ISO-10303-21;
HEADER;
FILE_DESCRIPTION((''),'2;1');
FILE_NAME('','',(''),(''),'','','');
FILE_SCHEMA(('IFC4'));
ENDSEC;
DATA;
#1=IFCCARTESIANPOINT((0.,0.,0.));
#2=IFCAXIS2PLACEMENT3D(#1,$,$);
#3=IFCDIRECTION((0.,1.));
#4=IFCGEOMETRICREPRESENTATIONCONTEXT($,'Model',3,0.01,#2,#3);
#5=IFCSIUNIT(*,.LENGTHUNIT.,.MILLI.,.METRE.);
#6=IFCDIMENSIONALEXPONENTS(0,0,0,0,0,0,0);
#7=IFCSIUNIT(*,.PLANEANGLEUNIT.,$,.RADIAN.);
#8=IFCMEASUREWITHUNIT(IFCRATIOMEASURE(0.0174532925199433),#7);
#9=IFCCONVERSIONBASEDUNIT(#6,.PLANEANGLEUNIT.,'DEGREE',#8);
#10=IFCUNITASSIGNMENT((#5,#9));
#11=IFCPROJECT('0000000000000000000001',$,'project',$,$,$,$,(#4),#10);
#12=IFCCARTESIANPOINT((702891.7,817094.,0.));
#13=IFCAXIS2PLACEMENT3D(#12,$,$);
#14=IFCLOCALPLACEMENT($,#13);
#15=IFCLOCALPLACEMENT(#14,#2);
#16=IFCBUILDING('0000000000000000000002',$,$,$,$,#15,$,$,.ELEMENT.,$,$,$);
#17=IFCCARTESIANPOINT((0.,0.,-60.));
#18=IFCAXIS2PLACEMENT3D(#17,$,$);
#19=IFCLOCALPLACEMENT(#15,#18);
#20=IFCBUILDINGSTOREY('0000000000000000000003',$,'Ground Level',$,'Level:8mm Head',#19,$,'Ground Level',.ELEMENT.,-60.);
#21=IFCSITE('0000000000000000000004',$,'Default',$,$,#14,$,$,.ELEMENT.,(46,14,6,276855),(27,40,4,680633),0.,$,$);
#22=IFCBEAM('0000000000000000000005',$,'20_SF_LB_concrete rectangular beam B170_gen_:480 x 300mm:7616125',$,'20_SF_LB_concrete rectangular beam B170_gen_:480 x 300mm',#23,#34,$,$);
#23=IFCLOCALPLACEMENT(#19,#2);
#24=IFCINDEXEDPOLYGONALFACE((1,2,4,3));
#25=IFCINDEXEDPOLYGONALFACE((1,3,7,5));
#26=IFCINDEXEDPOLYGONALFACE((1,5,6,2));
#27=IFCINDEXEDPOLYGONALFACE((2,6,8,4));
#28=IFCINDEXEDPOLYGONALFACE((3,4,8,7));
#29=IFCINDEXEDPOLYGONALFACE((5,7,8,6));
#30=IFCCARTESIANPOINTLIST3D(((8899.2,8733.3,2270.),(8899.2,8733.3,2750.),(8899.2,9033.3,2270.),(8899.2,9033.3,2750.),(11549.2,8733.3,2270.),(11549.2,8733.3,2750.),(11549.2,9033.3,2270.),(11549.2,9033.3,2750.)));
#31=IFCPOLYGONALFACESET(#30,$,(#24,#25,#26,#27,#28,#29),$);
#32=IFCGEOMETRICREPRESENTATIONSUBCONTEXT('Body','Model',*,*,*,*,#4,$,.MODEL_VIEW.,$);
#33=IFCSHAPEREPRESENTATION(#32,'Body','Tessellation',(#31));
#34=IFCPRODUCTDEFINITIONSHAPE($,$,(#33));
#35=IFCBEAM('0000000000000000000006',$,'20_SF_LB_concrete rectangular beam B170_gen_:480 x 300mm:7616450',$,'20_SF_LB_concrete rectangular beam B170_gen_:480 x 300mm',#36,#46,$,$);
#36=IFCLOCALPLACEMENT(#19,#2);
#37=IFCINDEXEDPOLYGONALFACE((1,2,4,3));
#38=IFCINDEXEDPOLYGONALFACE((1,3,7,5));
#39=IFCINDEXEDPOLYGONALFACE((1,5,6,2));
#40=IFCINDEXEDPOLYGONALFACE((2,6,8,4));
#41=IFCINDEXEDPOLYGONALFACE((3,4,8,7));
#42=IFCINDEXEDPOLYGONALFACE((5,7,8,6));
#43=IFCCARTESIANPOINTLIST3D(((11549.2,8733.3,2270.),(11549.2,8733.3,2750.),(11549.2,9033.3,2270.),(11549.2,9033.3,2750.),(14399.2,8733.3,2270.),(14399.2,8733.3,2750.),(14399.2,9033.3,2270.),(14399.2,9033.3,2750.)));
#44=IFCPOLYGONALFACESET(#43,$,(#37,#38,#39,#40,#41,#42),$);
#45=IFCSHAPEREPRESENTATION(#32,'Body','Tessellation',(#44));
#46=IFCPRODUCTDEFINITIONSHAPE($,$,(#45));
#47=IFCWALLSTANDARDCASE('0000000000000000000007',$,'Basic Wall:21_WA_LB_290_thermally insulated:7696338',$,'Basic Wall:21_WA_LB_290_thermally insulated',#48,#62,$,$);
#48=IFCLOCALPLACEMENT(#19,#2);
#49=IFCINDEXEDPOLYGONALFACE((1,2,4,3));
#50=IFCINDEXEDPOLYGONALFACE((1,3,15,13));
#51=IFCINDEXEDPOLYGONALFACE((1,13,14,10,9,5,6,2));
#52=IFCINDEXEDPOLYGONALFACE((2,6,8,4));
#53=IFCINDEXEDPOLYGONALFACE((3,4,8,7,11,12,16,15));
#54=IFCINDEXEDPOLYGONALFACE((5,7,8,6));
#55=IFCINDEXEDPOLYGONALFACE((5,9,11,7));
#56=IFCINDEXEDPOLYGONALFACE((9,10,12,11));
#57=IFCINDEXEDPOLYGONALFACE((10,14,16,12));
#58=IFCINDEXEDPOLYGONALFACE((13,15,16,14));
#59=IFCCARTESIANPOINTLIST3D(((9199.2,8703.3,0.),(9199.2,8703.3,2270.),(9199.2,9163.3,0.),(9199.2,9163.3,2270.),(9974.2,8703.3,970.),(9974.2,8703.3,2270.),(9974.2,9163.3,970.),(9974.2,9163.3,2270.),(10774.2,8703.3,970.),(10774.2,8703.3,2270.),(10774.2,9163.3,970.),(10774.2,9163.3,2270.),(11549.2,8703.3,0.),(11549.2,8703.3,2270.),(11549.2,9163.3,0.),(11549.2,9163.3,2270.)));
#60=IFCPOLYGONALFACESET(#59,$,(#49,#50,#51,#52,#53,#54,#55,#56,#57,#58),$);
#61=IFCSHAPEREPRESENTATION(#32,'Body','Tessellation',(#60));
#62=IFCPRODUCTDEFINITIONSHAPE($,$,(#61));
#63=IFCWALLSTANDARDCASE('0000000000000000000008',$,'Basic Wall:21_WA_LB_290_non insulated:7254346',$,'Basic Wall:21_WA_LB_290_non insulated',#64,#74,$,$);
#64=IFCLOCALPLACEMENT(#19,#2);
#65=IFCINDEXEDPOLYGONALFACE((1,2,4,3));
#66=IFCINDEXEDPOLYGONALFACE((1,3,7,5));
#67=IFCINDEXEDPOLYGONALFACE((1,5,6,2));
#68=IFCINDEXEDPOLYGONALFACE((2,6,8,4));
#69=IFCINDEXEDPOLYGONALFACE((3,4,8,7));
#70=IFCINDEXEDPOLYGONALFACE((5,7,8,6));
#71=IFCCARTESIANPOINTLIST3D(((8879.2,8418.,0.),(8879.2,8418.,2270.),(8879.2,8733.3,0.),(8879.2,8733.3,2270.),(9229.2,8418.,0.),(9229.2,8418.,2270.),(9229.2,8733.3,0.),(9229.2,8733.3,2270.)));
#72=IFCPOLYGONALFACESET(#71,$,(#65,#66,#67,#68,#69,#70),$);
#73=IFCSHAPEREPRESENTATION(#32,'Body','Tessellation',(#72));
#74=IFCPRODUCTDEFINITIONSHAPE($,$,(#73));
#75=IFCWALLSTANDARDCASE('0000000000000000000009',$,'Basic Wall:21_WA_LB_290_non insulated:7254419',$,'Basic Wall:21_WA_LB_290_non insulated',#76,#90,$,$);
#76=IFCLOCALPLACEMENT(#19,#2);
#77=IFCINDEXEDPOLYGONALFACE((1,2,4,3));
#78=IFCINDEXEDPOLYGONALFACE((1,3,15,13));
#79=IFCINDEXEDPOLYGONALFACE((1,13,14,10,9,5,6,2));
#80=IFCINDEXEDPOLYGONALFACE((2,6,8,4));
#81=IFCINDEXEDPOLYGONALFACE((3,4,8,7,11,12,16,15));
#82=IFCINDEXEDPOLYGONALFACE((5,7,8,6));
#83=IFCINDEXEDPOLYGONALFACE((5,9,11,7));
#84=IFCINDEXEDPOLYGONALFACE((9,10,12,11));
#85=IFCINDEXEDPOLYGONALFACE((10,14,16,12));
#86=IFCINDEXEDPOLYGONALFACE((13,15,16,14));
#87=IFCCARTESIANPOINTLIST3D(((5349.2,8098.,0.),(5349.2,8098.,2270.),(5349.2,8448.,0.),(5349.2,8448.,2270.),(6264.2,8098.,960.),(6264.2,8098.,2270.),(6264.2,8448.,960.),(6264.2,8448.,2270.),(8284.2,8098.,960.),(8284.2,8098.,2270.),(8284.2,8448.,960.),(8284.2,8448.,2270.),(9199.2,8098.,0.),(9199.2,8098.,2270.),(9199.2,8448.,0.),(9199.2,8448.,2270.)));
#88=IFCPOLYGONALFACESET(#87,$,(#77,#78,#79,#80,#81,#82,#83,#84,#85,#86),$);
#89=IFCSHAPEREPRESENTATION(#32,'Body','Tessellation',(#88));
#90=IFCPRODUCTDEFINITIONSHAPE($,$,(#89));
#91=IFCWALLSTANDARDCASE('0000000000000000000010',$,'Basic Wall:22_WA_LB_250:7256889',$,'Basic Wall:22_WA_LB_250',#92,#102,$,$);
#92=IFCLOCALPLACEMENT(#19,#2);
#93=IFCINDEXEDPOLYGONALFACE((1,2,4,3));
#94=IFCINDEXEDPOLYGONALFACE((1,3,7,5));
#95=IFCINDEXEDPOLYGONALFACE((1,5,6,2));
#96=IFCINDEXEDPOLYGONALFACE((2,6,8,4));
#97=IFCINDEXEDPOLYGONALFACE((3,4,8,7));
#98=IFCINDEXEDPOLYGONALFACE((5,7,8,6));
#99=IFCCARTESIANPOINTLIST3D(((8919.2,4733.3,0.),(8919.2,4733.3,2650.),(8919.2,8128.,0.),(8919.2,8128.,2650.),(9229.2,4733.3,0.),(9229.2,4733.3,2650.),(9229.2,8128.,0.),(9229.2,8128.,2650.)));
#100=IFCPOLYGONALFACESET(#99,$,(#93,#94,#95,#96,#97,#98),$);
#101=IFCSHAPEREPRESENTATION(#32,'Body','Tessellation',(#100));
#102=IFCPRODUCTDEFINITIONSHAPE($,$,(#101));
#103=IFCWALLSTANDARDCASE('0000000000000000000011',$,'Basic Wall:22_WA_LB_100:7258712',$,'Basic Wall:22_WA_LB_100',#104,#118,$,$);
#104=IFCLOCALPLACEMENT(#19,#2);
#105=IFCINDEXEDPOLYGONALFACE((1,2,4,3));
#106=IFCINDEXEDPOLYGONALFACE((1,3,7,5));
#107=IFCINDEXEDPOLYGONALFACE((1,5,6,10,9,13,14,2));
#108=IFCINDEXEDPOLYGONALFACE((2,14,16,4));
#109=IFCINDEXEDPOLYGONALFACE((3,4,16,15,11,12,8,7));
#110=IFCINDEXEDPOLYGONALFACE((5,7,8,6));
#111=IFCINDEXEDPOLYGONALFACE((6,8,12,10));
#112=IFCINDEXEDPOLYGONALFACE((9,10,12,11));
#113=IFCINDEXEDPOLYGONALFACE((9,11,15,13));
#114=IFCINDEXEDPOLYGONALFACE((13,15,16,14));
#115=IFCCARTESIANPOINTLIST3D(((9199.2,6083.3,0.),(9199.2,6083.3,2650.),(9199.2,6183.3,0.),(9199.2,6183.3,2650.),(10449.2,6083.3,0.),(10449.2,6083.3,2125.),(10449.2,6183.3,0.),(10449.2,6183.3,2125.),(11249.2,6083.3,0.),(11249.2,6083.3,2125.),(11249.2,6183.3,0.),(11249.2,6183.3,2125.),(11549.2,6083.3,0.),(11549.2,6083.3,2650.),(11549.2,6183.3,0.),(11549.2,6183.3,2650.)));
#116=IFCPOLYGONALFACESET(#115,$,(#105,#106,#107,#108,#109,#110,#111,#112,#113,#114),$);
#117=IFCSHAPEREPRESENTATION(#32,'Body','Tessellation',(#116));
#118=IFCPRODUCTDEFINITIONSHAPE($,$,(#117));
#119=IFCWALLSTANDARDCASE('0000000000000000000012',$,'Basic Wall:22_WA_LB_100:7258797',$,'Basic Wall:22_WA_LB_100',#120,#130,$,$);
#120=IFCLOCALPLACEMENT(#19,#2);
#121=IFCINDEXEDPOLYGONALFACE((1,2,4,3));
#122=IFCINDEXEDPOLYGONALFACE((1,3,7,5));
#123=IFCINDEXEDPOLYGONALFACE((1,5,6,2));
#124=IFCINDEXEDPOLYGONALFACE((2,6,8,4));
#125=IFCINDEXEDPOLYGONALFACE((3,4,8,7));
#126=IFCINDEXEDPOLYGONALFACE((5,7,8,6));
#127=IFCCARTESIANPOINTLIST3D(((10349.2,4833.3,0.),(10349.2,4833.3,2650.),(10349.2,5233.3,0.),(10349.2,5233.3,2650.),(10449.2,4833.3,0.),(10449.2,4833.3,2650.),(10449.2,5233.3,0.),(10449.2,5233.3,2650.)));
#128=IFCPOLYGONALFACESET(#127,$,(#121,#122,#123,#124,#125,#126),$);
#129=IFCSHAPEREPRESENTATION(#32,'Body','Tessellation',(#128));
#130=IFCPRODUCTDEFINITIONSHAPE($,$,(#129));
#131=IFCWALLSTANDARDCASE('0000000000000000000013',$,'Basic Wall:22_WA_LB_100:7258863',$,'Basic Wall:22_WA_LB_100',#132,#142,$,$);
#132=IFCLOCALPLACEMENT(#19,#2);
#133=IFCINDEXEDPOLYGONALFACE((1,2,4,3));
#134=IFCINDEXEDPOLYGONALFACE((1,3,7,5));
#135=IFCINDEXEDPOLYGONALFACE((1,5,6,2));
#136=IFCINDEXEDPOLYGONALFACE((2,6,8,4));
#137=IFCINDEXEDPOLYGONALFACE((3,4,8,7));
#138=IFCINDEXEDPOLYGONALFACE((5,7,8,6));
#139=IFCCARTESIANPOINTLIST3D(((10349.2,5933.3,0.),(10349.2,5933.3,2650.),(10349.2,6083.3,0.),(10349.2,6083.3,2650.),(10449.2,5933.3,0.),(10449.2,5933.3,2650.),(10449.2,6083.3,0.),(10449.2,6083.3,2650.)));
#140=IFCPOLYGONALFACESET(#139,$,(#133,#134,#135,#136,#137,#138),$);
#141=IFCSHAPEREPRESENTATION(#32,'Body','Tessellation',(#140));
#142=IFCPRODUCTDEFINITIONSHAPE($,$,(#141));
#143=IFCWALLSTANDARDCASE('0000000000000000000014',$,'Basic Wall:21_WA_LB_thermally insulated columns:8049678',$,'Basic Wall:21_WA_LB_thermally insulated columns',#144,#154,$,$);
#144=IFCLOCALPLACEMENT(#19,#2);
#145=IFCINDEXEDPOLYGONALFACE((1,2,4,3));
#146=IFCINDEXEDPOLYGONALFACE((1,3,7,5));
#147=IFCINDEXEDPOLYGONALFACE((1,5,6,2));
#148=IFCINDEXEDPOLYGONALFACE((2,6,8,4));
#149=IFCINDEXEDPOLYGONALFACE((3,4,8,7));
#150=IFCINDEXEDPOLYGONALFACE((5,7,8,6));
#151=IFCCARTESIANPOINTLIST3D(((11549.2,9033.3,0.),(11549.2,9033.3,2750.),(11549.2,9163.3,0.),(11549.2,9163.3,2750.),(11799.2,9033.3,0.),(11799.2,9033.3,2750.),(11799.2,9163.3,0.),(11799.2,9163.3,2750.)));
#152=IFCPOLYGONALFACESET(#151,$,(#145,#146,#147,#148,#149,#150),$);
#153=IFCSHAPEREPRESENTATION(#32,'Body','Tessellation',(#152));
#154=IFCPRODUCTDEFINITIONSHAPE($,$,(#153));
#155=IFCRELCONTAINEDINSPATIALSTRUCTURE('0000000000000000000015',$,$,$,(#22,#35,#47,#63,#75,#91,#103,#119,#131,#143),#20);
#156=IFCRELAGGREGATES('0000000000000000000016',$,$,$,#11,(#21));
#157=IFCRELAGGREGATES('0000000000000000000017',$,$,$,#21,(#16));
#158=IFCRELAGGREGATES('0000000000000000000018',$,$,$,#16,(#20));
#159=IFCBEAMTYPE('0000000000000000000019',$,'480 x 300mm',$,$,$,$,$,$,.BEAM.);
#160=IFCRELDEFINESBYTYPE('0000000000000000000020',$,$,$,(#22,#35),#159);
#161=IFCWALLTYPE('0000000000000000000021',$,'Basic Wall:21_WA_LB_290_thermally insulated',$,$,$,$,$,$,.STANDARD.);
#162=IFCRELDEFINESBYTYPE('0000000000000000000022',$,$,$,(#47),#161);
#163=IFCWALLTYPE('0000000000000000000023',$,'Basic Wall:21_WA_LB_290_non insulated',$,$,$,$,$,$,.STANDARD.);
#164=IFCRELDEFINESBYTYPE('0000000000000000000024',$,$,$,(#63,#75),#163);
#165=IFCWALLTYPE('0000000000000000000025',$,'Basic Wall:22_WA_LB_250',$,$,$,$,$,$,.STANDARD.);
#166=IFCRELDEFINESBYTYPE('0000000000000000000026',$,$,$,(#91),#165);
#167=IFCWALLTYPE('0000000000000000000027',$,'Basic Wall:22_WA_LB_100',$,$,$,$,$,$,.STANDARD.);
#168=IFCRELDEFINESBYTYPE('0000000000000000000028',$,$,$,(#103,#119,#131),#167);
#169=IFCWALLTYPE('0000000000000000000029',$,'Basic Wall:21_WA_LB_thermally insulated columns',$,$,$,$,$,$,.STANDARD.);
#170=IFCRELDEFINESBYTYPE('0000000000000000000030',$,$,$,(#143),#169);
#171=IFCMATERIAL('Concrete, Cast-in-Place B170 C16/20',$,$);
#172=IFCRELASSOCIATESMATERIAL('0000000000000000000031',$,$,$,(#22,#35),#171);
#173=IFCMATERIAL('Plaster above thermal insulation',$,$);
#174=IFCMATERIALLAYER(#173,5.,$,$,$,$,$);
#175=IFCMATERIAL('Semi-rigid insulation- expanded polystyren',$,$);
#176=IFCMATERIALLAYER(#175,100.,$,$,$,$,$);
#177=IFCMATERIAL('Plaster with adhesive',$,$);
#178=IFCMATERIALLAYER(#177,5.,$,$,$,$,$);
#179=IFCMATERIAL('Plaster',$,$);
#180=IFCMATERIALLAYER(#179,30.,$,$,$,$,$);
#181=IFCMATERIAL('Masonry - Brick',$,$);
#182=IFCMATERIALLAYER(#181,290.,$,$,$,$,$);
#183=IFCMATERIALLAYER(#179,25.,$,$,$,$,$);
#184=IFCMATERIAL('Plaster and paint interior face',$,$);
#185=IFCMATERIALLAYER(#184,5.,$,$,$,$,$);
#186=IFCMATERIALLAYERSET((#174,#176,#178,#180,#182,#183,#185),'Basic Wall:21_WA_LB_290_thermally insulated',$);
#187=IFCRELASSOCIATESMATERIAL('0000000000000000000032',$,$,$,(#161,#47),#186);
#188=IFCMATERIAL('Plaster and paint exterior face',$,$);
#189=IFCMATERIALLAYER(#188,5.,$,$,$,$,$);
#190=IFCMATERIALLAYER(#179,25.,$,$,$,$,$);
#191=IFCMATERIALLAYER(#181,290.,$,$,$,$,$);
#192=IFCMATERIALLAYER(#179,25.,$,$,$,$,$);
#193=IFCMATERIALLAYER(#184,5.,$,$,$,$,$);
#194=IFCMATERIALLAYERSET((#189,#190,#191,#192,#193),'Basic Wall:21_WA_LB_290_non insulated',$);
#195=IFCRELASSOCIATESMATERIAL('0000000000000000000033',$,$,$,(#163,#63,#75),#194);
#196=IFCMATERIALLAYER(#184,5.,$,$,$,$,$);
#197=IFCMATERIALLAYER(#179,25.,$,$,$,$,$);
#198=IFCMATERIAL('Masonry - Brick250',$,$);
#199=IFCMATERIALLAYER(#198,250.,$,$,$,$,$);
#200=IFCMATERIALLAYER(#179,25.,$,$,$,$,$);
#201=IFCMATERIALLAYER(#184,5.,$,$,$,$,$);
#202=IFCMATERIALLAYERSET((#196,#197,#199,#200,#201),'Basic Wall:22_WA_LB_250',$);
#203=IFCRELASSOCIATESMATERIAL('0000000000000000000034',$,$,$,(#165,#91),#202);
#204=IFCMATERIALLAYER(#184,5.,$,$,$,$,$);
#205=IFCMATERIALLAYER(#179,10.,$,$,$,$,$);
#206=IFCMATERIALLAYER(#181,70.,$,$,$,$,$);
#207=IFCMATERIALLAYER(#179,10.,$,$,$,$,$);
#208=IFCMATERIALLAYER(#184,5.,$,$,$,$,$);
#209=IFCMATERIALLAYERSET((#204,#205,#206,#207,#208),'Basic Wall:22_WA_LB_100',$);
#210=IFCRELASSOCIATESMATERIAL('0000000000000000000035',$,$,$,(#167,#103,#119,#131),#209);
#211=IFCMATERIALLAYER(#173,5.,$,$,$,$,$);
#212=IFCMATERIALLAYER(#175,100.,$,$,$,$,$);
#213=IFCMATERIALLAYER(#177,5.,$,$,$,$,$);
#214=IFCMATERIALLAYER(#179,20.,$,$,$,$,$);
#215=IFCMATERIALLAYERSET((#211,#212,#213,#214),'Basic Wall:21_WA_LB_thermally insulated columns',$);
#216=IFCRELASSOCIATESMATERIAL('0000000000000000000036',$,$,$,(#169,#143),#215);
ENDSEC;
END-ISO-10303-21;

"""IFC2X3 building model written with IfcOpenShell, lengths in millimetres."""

from ifc_helpers import new_model, entity, si_unit, converted_unit, direction, frame, frame_2d, origin, origin_2d_with_axis, place, context, subcontext, project, spatial, rectangle, extrude, clip, halfspace, material, layer, layer_set, layer_usage, type_object, element, save


model = new_model("IFC2X3")

# Units and contexts
model_context = context("Model", 3, precision=0.01, world=origin(), true_north=direction((0.0, 1.0)))
body_context = subcontext(model_context, "Body", "Model", "MODEL_VIEW")
ifc_project = project(units=[si_unit("LENGTHUNIT", "METRE", prefix="MILLI"), converted_unit("PLANEANGLEUNIT", "DEGREE", entity("IfcRatioMeasure", 0.0174532925199433), si_unit("PLANEANGLEUNIT", "RADIAN"), dimensions=[0, 0, 0, 0, 0, 0, 0])], contexts=[model_context])

# Site, building, storey
site_placement = place(None, frame((702891.7, 817094.0, 0.0)))
site = spatial("IfcSite", under=ifc_project, at=site_placement, Name="Default", CompositionType="ELEMENT", RefLatitude=(46, 14, 6, 276855), RefLongitude=(27, 40, 4, 680633), RefElevation=0.0)
building_placement = place(site_placement, origin())
building = spatial("IfcBuilding", under=site, at=building_placement, CompositionType="ELEMENT")
storey_placement = place(building_placement, frame((0.0, 0.0, -60.0)))
storey = spatial("IfcBuildingStorey", under=building, at=storey_placement, Name="Ground Level", ObjectType="Level:8mm Head", LongName="Ground Level", CompositionType="ELEMENT", Elevation=-60.0)

# Beams
ifc_material_1 = material(Name="Concrete, Cast-in-Place B170 C16/20")
beam_type = type_object("IfcBeamType", Name="480 x 300mm", PredefinedType="BEAM")
beam_1_placement = place(storey_placement, frame((8899.2, 8883.3, 0.0)))
element("IfcBeam", 1, at=beam_1_placement, inside=storey, type_object=beam_type, material=ifc_material_1, Name="20_SF_LB_concrete rectangular beam B170_gen_:480 x 300mm:7616125", ObjectType="20_SF_LB_concrete rectangular beam B170_gen_:480 x 300mm", context=body_context, shape_type="SweptSolid", body=[
    extrude(rectangle(XDim=480.0, YDim=300.0, at=frame_2d((0.0, 0.0), x_axis=(1.0, 0.0))), frame((0.0, 0.0, 2510.0), z_axis=(1.0, 0.0, 0.0), x_axis=(0.0, 0.0, -1.0)), (0.0, 0.0, 1.0), 2650.0),
])
beam_2_placement = place(storey_placement, frame((11549.2, 8883.3, 0.0)))
element("IfcBeam", 2, at=beam_2_placement, inside=storey, type_object=beam_type, material=ifc_material_1, Name="20_SF_LB_concrete rectangular beam B170_gen_:480 x 300mm:7616450", ObjectType="20_SF_LB_concrete rectangular beam B170_gen_:480 x 300mm", context=body_context, shape_type="SweptSolid", body=[
    extrude(rectangle(XDim=480.0, YDim=300.0, at=frame_2d((0.0, 0.0), x_axis=(1.0, 0.0))), frame((0.0, 0.0, 2510.0), z_axis=(1.0, 0.0, 0.0), x_axis=(0.0, 0.0, -1.0)), (0.0, 0.0, 1.0), 2850.0),
])

# Wall, opening
ifc_material_2 = material(Name="Plaster above thermal insulation")
ifc_layer_1 = layer(ifc_material_2, 5.0)
ifc_material_3 = material(Name="Semi-rigid insulation- expanded polystyren")
ifc_layer_2 = layer(ifc_material_3, 100.0)
ifc_material_4 = material(Name="Plaster with adhesive")
ifc_layer_3 = layer(ifc_material_4, 5.0)
ifc_material_5 = material(Name="Plaster")
ifc_layer_4 = layer(ifc_material_5, 30.0)
ifc_material_6 = material(Name="Masonry - Brick")
ifc_layer_5 = layer(ifc_material_6, 290.0)
ifc_layer_6 = layer(ifc_material_5, 25.0)
ifc_material_7 = material(Name="Plaster and paint interior face")
ifc_layer_7 = layer(ifc_material_7, 5.0)
ifc_layer_set_1 = layer_set([ifc_layer_1, ifc_layer_2, ifc_layer_3, ifc_layer_4, ifc_layer_5, ifc_layer_6, ifc_layer_7], Name="Basic Wall:21_WA_LB_290_thermally insulated")
ifc_layer_usage_1 = layer_usage(ifc_layer_set_1, "AXIS2", "POSITIVE", -230.0)
wall_type_1 = type_object("IfcWallType", Name="Basic Wall:21_WA_LB_290_thermally insulated", PredefinedType="STANDARD", material=ifc_layer_set_1)
wall_1_placement = place(storey_placement, frame((11549.2, 8933.3, 0.0), z_axis=(0.0, 0.0, 1.0), x_axis=(-1.0, 0.0, 0.0)))
wall_1 = element("IfcWallStandardCase", 3, at=wall_1_placement, inside=storey, type_object=wall_type_1, material=ifc_layer_usage_1, Name="Basic Wall:21_WA_LB_290_thermally insulated:7696338", ObjectType="Basic Wall:21_WA_LB_290_thermally insulated", context=body_context, shape_type="SweptSolid", body=[
    extrude(rectangle(XDim=2350.0, YDim=460.0, at=frame_2d((1175.0, 0.0), x_axis=(-1.0, 0.0))), origin(), (0.0, 0.0, 1.0), 2270.0),
])
opening_1_placement = place(wall_1_placement, frame((11549.2, 8933.3, 0.0), z_axis=(0.0, 0.0, 1.0), x_axis=(-1.0, 0.0, 0.0)))
element("IfcOpeningElement", 4, at=opening_1_placement, cuts=wall_1, ObjectType="Opening", context=body_context, shape_type="SweptSolid", body=[
    extrude(rectangle(XDim=1300.0, YDim=800.0, at=origin_2d_with_axis()), frame((10374.2, 9163.3, 1620.0), z_axis=(0.0, -1.0, 0.0), x_axis=(0.0, 0.0, -1.0)), (0.0, 0.0, 1.0), 460.0),
])

# Wall
ifc_material_8 = material(Name="Plaster and paint exterior face")
ifc_layer_8 = layer(ifc_material_8, 5.0)
ifc_layer_9 = layer(ifc_material_5, 25.0)
ifc_layer_10 = layer(ifc_material_6, 290.0)
ifc_layer_11 = layer(ifc_material_5, 25.0)
ifc_layer_12 = layer(ifc_material_7, 5.0)
ifc_layer_set_2 = layer_set([ifc_layer_8, ifc_layer_9, ifc_layer_10, ifc_layer_11, ifc_layer_12], Name="Basic Wall:21_WA_LB_290_non insulated")
ifc_layer_usage_2 = layer_usage(ifc_layer_set_2, "AXIS2", "POSITIVE", -175.0)
wall_type_2 = type_object("IfcWallType", Name="Basic Wall:21_WA_LB_290_non insulated", PredefinedType="STANDARD", material=ifc_layer_set_2)
wall_2_placement = place(storey_placement, frame((9054.2, 8733.3, 0.0), z_axis=(0.0, 0.0, 1.0), x_axis=(0.0, -1.0, 0.0)))
element("IfcWallStandardCase", 5, at=wall_2_placement, inside=storey, type_object=wall_type_2, material=ifc_layer_usage_2, Name="Basic Wall:21_WA_LB_290_non insulated:7254346", ObjectType="Basic Wall:21_WA_LB_290_non insulated", context=body_context, shape_type="SweptSolid", body=[
    extrude(rectangle(XDim=315.3, YDim=350.0, at=frame_2d((157.7, 0.0), x_axis=(-1.0, 0.0))), origin(), (0.0, 0.0, 1.0), 2270.0),
])

# Wall, opening
ifc_layer_usage_3 = layer_usage(ifc_layer_set_2, "AXIS2", "POSITIVE", -175.0)
wall_3_placement = place(storey_placement, frame((9199.2, 8273.0, 0.0), z_axis=(0.0, 0.0, 1.0), x_axis=(-1.0, 0.0, 0.0)))
wall_3 = element("IfcWallStandardCase", 6, at=wall_3_placement, inside=storey, type_object=wall_type_2, material=ifc_layer_usage_3, Name="Basic Wall:21_WA_LB_290_non insulated:7254419", ObjectType="Basic Wall:21_WA_LB_290_non insulated", context=body_context, shape_type="SweptSolid", body=[
    extrude(rectangle(XDim=3850.0, YDim=350.0, at=frame_2d((1925.0, 0.0), x_axis=(-1.0, 0.0))), origin(), (0.0, 0.0, 1.0), 2270.0),
])
opening_2_placement = place(wall_3_placement, frame((2935.0, 175.0, 960.0)))
element("IfcOpeningElement", 7, at=opening_2_placement, cuts=wall_3, ObjectType="Opening", context=body_context, shape_type="SweptSolid", body=[
    extrude(rectangle(XDim=1320.0, YDim=2020.0, at=frame_2d((660.0, 1010.0), x_axis=(1.0, 0.0))), frame((0.0, 0.0, 0.0), z_axis=(0.0, -1.0, 0.0), x_axis=(0.0, 0.0, 1.0)), (0.0, 0.0, 1.0), 350.0),
])

# Wall
ifc_layer_13 = layer(ifc_material_7, 5.0)
ifc_layer_14 = layer(ifc_material_5, 25.0)
ifc_material_9 = material(Name="Masonry - Brick250")
ifc_layer_15 = layer(ifc_material_9, 250.0)
ifc_layer_16 = layer(ifc_material_5, 25.0)
ifc_layer_17 = layer(ifc_material_7, 5.0)
ifc_layer_set_3 = layer_set([ifc_layer_13, ifc_layer_14, ifc_layer_15, ifc_layer_16, ifc_layer_17], Name="Basic Wall:22_WA_LB_250")
ifc_layer_usage_4 = layer_usage(ifc_layer_set_3, "AXIS2", "NEGATIVE", 155.0)
wall_type_3 = type_object("IfcWallType", Name="Basic Wall:22_WA_LB_250", PredefinedType="STANDARD", material=ifc_layer_set_3)
wall_4_placement = place(storey_placement, frame((9074.2, 8128.0, 0.0), z_axis=(0.0, 0.0, 1.0), x_axis=(0.0, -1.0, 0.0)))
element("IfcWallStandardCase", 8, at=wall_4_placement, inside=storey, type_object=wall_type_3, material=ifc_layer_usage_4, Name="Basic Wall:22_WA_LB_250:7256889", ObjectType="Basic Wall:22_WA_LB_250", context=body_context, shape_type="SweptSolid", body=[
    extrude(rectangle(XDim=3394.7, YDim=310.0, at=frame_2d((1697.3, 0.0), x_axis=(-1.0, 0.0))), origin(), (0.0, 0.0, 1.0), 2650.0),
])

# Wall, opening
ifc_layer_18 = layer(ifc_material_7, 5.0)
ifc_layer_19 = layer(ifc_material_5, 10.0)
ifc_layer_20 = layer(ifc_material_6, 70.0)
ifc_layer_21 = layer(ifc_material_5, 10.0)
ifc_layer_22 = layer(ifc_material_7, 5.0)
ifc_layer_set_4 = layer_set([ifc_layer_18, ifc_layer_19, ifc_layer_20, ifc_layer_21, ifc_layer_22], Name="Basic Wall:22_WA_LB_100")
ifc_layer_usage_5 = layer_usage(ifc_layer_set_4, "AXIS2", "NEGATIVE", 50.0)
wall_type_4 = type_object("IfcWallType", Name="Basic Wall:22_WA_LB_100", PredefinedType="STANDARD", material=ifc_layer_set_4)
wall_5_placement = place(storey_placement, frame((9199.2, 6133.3, 0.0)))
wall_5 = element("IfcWallStandardCase", 9, at=wall_5_placement, inside=storey, type_object=wall_type_4, material=ifc_layer_usage_5, Name="Basic Wall:22_WA_LB_100:7258712", ObjectType="Basic Wall:22_WA_LB_100", context=body_context, shape_type="SweptSolid", body=[
    extrude(rectangle(XDim=2350.0, YDim=100.0, at=frame_2d((1175.0, 0.0), x_axis=(-1.0, 0.0))), origin(), (0.0, 0.0, 1.0), 2650.0),
])
opening_3_placement = place(wall_5_placement, frame((-9199.2, -6133.3, 0.0)))
element("IfcOpeningElement", 10, at=opening_3_placement, cuts=wall_5, ObjectType="Opening", context=body_context, shape_type="SweptSolid", body=[
    extrude(rectangle(XDim=2125.0, YDim=800.0, at=frame_2d((0.0, 0.0), x_axis=(1.0, 0.0))), frame((10849.2, 4559.3, 1062.5), z_axis=(0.0, 1.0, 0.0), x_axis=(0.0, 0.0, 1.0)), (0.0, 0.0, 1.0), 3048.0),
])

# Walls
ifc_layer_usage_6 = layer_usage(ifc_layer_set_4, "AXIS2", "NEGATIVE", 50.0)
wall_6_placement = place(storey_placement, frame((10399.2, 4833.3, 0.0), z_axis=(0.0, 0.0, 1.0), x_axis=(0.0, 1.0, 0.0)))
element("IfcWallStandardCase", 11, at=wall_6_placement, inside=storey, type_object=wall_type_4, material=ifc_layer_usage_6, Name="Basic Wall:22_WA_LB_100:7258797", ObjectType="Basic Wall:22_WA_LB_100", context=body_context, shape_type="SweptSolid", body=[
    extrude(rectangle(XDim=400.0, YDim=100.0, at=frame_2d((200.0, 0.0), x_axis=(-1.0, 0.0))), origin(), (0.0, 0.0, 1.0), 2650.0),
])
ifc_layer_usage_7 = layer_usage(ifc_layer_set_4, "AXIS2", "NEGATIVE", 50.0)
wall_7_placement = place(storey_placement, frame((10399.2, 6083.3, 0.0), z_axis=(0.0, 0.0, 1.0), x_axis=(0.0, -1.0, 0.0)))
element("IfcWallStandardCase", 12, at=wall_7_placement, inside=storey, type_object=wall_type_4, material=ifc_layer_usage_7, Name="Basic Wall:22_WA_LB_100:7258863", ObjectType="Basic Wall:22_WA_LB_100", context=body_context, shape_type="SweptSolid", body=[
    extrude(rectangle(XDim=150.0, YDim=100.0, at=frame_2d((75.0, 0.0), x_axis=(-1.0, 0.0))), origin(), (0.0, 0.0, 1.0), 2650.0),
])
ifc_layer_23 = layer(ifc_material_2, 5.0)
ifc_layer_24 = layer(ifc_material_3, 100.0)
ifc_layer_25 = layer(ifc_material_4, 5.0)
ifc_layer_26 = layer(ifc_material_5, 20.0)
ifc_layer_set_5 = layer_set([ifc_layer_23, ifc_layer_24, ifc_layer_25, ifc_layer_26], Name="Basic Wall:21_WA_LB_thermally insulated columns")
ifc_layer_usage_8 = layer_usage(ifc_layer_set_5, "AXIS2", "NEGATIVE", 65.0)
wall_type_5 = type_object("IfcWallType", Name="Basic Wall:21_WA_LB_thermally insulated columns", PredefinedType="STANDARD", material=ifc_layer_set_5)
wall_8_placement = place(storey_placement, frame((11549.2, 9098.3, 0.0)))
element("IfcWallStandardCase", 13, at=wall_8_placement, inside=storey, type_object=wall_type_5, material=ifc_layer_usage_8, Name="Basic Wall:21_WA_LB_thermally insulated columns:8049678", ObjectType="Basic Wall:21_WA_LB_thermally insulated columns", context=body_context, shape_type="Clipping", body=[
    clip(extrude(rectangle(XDim=250.0, YDim=130.0, at=frame_2d((125.0, 0.0), x_axis=(-1.0, 0.0))), origin(), (0.0, 0.0, 1.0), 2750.0), halfspace(origin(), True)),
])

save(model, "model.ifc")
